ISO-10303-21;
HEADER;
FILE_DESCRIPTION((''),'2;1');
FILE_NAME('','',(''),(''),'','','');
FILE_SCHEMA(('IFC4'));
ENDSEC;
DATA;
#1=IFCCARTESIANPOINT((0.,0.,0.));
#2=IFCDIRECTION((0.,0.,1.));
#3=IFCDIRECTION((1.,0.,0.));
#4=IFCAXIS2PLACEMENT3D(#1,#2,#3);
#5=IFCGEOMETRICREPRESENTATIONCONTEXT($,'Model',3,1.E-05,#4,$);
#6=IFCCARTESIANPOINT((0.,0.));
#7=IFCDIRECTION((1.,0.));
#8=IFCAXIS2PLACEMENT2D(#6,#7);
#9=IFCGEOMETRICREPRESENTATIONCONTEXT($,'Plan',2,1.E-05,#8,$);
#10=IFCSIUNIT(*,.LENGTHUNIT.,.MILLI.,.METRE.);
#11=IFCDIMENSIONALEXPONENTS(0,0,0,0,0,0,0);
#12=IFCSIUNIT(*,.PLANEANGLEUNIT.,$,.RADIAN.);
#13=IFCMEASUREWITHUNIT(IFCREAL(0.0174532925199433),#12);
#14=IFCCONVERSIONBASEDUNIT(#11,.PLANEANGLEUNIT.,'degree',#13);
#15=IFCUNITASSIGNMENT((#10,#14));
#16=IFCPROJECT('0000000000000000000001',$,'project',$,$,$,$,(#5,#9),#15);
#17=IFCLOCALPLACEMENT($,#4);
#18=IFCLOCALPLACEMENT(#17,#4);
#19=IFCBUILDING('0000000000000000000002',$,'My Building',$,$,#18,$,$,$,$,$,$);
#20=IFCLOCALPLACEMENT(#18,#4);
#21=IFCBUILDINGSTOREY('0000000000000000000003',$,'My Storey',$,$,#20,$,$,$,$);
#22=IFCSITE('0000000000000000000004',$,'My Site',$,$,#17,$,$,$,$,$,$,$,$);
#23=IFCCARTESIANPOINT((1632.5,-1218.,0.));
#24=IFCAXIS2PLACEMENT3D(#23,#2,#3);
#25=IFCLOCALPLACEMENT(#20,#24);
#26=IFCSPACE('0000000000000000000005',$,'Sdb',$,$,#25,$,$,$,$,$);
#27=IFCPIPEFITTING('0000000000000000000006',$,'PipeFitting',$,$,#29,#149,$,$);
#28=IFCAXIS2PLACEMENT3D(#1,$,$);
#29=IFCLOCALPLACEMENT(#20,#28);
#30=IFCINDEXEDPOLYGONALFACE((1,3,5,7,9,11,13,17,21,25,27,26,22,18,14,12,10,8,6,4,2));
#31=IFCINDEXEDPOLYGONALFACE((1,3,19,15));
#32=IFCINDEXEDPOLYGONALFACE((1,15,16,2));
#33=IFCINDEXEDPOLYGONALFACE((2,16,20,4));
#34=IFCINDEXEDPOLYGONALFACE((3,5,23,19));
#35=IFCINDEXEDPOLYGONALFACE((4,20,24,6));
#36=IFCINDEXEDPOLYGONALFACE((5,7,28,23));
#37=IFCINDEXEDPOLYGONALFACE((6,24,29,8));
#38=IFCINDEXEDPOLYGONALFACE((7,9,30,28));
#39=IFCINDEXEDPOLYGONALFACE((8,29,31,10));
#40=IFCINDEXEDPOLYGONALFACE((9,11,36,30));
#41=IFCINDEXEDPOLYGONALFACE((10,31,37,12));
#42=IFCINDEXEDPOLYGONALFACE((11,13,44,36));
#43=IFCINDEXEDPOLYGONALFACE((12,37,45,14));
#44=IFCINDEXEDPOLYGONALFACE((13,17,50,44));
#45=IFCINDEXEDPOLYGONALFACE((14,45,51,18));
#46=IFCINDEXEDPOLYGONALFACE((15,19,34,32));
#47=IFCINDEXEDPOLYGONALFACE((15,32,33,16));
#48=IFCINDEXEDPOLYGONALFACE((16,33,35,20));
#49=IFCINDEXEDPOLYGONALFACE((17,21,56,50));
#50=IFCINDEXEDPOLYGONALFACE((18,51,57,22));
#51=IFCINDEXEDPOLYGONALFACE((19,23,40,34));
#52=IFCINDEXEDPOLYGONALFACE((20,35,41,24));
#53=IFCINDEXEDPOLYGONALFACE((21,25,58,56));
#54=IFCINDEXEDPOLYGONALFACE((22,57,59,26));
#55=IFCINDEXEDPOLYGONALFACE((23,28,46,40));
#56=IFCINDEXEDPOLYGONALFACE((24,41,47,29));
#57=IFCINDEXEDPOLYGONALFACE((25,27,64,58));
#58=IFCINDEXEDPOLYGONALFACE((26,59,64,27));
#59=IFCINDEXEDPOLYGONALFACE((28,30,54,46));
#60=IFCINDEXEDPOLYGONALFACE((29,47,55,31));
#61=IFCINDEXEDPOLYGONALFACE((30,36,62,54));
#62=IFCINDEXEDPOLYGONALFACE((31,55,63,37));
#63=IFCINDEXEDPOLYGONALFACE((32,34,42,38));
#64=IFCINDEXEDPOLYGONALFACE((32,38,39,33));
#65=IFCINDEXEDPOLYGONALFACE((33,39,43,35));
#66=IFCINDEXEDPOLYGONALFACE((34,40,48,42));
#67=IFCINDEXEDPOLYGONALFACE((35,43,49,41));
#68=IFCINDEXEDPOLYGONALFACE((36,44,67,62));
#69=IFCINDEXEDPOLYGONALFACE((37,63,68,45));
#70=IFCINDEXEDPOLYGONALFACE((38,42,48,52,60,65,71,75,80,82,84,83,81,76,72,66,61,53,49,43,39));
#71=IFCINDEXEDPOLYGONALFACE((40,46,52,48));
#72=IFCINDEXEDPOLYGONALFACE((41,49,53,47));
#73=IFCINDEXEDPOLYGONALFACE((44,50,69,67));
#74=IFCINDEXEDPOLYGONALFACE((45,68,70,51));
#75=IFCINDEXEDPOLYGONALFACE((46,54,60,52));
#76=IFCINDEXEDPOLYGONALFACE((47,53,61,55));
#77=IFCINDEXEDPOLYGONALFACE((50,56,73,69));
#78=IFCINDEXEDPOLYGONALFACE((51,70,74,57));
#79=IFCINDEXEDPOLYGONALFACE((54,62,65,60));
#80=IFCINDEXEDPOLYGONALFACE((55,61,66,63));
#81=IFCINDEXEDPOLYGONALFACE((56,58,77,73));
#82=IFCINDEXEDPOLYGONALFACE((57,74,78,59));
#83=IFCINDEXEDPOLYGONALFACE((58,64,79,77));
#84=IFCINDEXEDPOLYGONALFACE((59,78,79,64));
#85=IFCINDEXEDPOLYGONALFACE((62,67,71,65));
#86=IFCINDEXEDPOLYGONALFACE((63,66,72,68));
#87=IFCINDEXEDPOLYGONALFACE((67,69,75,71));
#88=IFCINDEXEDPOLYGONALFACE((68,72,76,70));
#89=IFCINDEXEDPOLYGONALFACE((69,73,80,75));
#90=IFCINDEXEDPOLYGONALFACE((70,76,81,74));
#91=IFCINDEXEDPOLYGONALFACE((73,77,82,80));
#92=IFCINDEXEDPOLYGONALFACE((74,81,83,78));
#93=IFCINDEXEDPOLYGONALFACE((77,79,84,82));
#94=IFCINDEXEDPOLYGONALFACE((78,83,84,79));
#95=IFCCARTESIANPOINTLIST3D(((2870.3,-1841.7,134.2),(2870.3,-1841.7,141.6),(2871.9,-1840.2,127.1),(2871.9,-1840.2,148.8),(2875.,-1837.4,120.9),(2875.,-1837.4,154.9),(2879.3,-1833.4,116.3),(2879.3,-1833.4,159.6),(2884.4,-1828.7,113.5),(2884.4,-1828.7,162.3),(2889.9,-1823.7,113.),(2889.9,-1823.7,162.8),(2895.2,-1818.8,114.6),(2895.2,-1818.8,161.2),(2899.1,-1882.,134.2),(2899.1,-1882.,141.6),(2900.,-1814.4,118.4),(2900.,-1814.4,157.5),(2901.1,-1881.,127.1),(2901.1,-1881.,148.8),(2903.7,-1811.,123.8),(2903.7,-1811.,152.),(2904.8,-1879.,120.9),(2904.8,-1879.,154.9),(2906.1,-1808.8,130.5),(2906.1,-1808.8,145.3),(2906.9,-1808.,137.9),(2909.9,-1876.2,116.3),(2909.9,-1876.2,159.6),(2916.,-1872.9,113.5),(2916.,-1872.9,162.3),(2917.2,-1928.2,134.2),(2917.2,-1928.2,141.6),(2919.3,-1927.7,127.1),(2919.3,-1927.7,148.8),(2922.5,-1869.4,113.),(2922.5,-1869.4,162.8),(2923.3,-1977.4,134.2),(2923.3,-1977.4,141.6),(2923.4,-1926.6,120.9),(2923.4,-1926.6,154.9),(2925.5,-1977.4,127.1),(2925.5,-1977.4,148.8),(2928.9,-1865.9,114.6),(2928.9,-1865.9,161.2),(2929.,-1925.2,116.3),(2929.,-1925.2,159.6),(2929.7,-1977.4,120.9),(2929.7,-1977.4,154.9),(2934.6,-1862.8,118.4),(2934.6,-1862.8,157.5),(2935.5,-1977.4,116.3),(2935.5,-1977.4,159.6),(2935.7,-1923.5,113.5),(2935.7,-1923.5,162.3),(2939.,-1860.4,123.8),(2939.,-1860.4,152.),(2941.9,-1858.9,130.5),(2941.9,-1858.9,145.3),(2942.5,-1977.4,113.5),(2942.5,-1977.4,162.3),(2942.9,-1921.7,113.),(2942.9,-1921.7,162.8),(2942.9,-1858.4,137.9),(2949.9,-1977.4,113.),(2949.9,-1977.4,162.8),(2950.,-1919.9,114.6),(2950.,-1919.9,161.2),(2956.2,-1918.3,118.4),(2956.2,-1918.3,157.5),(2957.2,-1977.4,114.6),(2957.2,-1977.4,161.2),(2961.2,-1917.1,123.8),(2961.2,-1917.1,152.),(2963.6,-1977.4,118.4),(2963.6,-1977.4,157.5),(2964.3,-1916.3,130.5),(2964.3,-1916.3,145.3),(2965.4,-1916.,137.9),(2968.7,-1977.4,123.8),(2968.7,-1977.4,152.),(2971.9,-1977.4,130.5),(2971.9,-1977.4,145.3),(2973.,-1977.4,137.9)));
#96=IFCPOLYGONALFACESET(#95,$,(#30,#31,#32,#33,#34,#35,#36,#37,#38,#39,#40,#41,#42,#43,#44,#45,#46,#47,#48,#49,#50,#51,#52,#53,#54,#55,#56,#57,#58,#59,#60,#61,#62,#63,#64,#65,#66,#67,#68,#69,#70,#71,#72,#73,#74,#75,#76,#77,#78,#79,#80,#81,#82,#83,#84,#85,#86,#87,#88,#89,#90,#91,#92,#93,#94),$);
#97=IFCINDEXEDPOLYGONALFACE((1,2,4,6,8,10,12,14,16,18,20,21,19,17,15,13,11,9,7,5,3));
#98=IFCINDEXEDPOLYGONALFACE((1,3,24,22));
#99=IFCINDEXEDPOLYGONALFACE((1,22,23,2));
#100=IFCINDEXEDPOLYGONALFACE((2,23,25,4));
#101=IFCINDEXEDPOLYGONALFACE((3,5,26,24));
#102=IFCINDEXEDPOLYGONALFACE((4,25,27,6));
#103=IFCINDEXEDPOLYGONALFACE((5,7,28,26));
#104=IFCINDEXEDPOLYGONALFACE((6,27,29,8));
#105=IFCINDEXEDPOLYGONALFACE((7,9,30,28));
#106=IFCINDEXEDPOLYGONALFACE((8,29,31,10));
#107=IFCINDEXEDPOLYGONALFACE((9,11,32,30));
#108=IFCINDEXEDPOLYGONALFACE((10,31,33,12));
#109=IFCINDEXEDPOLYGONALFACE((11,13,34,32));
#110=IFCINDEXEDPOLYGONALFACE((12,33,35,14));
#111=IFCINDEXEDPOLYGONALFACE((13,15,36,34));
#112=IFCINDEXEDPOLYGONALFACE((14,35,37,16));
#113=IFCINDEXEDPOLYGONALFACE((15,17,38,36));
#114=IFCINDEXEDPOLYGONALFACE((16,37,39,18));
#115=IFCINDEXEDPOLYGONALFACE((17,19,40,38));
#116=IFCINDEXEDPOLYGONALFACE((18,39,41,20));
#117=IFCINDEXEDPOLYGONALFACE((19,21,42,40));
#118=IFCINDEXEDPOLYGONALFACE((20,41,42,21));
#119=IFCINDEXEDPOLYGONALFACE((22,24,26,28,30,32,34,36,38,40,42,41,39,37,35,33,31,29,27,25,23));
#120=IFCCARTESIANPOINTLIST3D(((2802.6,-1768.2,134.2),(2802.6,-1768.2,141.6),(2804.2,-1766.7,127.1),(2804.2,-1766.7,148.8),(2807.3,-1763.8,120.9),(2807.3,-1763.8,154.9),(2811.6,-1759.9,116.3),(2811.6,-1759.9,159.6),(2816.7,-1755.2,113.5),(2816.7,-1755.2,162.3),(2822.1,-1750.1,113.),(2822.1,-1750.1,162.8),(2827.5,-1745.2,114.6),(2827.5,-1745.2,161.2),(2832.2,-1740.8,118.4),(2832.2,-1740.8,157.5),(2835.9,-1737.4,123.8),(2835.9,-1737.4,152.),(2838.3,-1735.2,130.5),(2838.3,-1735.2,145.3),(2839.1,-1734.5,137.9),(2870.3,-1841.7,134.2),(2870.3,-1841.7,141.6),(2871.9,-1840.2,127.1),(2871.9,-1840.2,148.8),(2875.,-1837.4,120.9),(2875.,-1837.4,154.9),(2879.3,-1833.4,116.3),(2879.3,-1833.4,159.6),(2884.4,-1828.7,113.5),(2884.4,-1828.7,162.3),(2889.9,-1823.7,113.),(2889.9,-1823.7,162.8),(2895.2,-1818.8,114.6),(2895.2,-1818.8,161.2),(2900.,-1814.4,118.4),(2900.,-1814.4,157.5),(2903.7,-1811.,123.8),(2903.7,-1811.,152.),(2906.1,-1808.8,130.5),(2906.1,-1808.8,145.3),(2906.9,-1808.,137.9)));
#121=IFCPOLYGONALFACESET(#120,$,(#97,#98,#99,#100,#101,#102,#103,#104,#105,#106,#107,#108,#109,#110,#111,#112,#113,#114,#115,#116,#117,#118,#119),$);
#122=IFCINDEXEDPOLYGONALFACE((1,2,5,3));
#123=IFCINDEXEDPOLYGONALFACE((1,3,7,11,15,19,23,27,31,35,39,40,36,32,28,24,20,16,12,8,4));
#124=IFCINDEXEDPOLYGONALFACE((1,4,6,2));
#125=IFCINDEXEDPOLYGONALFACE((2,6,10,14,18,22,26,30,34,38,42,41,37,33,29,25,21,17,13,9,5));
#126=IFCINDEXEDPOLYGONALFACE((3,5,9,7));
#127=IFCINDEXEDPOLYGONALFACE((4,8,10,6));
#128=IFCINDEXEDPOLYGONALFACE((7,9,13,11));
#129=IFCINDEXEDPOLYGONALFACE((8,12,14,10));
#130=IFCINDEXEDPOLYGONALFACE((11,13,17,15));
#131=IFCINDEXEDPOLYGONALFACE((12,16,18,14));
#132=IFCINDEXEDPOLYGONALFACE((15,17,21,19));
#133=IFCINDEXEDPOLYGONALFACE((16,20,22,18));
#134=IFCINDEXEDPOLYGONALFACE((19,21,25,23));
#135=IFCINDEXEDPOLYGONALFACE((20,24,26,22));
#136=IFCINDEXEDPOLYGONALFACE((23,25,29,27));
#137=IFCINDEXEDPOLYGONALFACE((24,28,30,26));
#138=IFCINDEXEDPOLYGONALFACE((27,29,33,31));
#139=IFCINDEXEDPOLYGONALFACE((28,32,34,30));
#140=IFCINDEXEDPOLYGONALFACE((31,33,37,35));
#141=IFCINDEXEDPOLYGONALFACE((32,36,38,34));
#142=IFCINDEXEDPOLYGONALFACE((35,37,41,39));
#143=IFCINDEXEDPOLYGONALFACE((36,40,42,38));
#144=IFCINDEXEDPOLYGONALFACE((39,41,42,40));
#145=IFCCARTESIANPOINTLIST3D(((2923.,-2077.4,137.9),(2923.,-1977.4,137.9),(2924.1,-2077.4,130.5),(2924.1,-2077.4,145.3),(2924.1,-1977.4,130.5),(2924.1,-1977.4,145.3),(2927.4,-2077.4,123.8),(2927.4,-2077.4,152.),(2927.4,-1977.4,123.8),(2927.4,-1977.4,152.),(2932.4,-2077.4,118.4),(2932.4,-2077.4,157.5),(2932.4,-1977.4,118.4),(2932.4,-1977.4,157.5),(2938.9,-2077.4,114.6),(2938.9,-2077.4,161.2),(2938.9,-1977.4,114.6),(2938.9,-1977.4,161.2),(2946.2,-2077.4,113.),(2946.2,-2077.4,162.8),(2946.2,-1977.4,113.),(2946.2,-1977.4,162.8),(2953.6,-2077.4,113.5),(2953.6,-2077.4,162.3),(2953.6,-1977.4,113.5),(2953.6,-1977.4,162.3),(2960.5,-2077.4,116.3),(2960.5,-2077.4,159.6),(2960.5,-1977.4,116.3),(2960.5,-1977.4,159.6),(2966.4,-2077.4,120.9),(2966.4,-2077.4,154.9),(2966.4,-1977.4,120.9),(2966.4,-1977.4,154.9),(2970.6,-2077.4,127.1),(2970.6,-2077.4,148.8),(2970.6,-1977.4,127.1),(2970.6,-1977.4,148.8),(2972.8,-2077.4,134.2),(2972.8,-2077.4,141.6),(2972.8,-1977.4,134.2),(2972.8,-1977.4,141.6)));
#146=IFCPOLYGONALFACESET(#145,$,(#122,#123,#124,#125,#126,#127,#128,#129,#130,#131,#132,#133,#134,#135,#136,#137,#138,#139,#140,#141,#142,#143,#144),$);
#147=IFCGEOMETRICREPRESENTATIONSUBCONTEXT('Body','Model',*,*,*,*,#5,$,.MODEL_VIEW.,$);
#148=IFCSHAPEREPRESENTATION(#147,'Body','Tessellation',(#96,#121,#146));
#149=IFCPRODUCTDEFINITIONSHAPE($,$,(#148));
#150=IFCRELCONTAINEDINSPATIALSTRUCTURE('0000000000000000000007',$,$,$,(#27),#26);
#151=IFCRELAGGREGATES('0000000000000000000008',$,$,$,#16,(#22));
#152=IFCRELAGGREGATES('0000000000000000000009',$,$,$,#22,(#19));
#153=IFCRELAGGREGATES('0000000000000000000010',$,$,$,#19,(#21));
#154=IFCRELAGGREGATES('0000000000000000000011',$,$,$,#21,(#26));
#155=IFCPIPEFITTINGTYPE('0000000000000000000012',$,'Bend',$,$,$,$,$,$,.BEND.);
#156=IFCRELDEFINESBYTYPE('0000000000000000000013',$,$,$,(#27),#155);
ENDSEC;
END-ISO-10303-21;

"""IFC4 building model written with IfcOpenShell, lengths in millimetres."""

from ifc_helpers import new_model, entity, si_unit, converted_unit, frame, origin_with_axes, origin_2d_with_axis, place, context, subcontext, project, spatial, circle, extrude, source, transform, mapped, type_object, type_shapes, element, save


model = new_model("IFC4")

# Units and contexts
model_context = context("Model", 3, precision=1e-05, world=origin_with_axes())
plan_context = context("Plan", 2, precision=1e-05, world=origin_2d_with_axis())
body_context = subcontext(model_context, "Body", "Model", "MODEL_VIEW")
ifc_project = project(units=[si_unit("LENGTHUNIT", "METRE", prefix="MILLI"), converted_unit("PLANEANGLEUNIT", "degree", entity("IfcReal", 0.0174532925199433), si_unit("PLANEANGLEUNIT", "RADIAN"), dimensions=[0, 0, 0, 0, 0, 0, 0])], contexts=[model_context, plan_context])

# Site, building, storey, space
site_placement = place(None, origin_with_axes())
site = spatial("IfcSite", under=ifc_project, at=site_placement, Name="My Site")
building_placement = place(site_placement, origin_with_axes())
building = spatial("IfcBuilding", under=site, at=building_placement, Name="My Building")
storey_placement = place(building_placement, origin_with_axes())
storey = spatial("IfcBuildingStorey", under=building, at=storey_placement, Name="My Storey")
space_1_placement = place(storey_placement, frame((1632.5, -1218.0, 0.0), z_axis=(0.0, 0.0, 1.0), x_axis=(1.0, 0.0, 0.0)))
space_1 = spatial("IfcSpace", under=storey, at=space_1_placement, Name="Sdb")

# Pipe fitting
pipe_fitting_type = type_object("IfcPipeFittingType", Name="Bend", PredefinedType="BEND")
shared_shape_1 = source(origin_with_axes(), body_context, "Body", "AdvancedSweptSolid", [
    entity("IfcSweptDiskSolid", entity("IfcIndexedPolyCurve", entity("IfcCartesianPointList3D", [[0.0, 0.0, 100.0], [-15.4, 0.0, 181.8], [-59.5, 0.0, 252.4]]), [entity("IfcArcIndex", [1, 2, 3])]), 25.0),
    extrude(circle(Radius=25.0), origin_with_axes(), (0.0, 0.0, 1.0), 100.0),
    extrude(circle(Radius=25.0), frame((-59.5, 0.0, 252.4), z_axis=(-0.677548, 0.0, 0.735479), x_axis=(-0.735479, 0.0, -0.677548)), (0.0, 0.0, 1.0), 100.0),
])
type_shapes(pipe_fitting_type, [shared_shape_1])
pipe_fitting_placement = place(space_1_placement, frame((1188.3, -533.4, 137.9), z_axis=(0.677548, -0.735479, 0.0), x_axis=(0.735479, 0.677548, 0.0)))
element("IfcPipeFitting", 1, at=pipe_fitting_placement, inside=space_1, type_object=pipe_fitting_type, Name="PipeFitting", context=body_context, shape_type="MappedRepresentation", body=[
    mapped(shared_shape_1, transform((0.0, 0.0, 0.0), x_axis=(1.0, 0.0, 0.0), y_axis=(0.0, 1.0, 0.0), z_axis=(0.0, 0.0, 1.0), scale=1.0)),
])

save(model, "model.ifc")
